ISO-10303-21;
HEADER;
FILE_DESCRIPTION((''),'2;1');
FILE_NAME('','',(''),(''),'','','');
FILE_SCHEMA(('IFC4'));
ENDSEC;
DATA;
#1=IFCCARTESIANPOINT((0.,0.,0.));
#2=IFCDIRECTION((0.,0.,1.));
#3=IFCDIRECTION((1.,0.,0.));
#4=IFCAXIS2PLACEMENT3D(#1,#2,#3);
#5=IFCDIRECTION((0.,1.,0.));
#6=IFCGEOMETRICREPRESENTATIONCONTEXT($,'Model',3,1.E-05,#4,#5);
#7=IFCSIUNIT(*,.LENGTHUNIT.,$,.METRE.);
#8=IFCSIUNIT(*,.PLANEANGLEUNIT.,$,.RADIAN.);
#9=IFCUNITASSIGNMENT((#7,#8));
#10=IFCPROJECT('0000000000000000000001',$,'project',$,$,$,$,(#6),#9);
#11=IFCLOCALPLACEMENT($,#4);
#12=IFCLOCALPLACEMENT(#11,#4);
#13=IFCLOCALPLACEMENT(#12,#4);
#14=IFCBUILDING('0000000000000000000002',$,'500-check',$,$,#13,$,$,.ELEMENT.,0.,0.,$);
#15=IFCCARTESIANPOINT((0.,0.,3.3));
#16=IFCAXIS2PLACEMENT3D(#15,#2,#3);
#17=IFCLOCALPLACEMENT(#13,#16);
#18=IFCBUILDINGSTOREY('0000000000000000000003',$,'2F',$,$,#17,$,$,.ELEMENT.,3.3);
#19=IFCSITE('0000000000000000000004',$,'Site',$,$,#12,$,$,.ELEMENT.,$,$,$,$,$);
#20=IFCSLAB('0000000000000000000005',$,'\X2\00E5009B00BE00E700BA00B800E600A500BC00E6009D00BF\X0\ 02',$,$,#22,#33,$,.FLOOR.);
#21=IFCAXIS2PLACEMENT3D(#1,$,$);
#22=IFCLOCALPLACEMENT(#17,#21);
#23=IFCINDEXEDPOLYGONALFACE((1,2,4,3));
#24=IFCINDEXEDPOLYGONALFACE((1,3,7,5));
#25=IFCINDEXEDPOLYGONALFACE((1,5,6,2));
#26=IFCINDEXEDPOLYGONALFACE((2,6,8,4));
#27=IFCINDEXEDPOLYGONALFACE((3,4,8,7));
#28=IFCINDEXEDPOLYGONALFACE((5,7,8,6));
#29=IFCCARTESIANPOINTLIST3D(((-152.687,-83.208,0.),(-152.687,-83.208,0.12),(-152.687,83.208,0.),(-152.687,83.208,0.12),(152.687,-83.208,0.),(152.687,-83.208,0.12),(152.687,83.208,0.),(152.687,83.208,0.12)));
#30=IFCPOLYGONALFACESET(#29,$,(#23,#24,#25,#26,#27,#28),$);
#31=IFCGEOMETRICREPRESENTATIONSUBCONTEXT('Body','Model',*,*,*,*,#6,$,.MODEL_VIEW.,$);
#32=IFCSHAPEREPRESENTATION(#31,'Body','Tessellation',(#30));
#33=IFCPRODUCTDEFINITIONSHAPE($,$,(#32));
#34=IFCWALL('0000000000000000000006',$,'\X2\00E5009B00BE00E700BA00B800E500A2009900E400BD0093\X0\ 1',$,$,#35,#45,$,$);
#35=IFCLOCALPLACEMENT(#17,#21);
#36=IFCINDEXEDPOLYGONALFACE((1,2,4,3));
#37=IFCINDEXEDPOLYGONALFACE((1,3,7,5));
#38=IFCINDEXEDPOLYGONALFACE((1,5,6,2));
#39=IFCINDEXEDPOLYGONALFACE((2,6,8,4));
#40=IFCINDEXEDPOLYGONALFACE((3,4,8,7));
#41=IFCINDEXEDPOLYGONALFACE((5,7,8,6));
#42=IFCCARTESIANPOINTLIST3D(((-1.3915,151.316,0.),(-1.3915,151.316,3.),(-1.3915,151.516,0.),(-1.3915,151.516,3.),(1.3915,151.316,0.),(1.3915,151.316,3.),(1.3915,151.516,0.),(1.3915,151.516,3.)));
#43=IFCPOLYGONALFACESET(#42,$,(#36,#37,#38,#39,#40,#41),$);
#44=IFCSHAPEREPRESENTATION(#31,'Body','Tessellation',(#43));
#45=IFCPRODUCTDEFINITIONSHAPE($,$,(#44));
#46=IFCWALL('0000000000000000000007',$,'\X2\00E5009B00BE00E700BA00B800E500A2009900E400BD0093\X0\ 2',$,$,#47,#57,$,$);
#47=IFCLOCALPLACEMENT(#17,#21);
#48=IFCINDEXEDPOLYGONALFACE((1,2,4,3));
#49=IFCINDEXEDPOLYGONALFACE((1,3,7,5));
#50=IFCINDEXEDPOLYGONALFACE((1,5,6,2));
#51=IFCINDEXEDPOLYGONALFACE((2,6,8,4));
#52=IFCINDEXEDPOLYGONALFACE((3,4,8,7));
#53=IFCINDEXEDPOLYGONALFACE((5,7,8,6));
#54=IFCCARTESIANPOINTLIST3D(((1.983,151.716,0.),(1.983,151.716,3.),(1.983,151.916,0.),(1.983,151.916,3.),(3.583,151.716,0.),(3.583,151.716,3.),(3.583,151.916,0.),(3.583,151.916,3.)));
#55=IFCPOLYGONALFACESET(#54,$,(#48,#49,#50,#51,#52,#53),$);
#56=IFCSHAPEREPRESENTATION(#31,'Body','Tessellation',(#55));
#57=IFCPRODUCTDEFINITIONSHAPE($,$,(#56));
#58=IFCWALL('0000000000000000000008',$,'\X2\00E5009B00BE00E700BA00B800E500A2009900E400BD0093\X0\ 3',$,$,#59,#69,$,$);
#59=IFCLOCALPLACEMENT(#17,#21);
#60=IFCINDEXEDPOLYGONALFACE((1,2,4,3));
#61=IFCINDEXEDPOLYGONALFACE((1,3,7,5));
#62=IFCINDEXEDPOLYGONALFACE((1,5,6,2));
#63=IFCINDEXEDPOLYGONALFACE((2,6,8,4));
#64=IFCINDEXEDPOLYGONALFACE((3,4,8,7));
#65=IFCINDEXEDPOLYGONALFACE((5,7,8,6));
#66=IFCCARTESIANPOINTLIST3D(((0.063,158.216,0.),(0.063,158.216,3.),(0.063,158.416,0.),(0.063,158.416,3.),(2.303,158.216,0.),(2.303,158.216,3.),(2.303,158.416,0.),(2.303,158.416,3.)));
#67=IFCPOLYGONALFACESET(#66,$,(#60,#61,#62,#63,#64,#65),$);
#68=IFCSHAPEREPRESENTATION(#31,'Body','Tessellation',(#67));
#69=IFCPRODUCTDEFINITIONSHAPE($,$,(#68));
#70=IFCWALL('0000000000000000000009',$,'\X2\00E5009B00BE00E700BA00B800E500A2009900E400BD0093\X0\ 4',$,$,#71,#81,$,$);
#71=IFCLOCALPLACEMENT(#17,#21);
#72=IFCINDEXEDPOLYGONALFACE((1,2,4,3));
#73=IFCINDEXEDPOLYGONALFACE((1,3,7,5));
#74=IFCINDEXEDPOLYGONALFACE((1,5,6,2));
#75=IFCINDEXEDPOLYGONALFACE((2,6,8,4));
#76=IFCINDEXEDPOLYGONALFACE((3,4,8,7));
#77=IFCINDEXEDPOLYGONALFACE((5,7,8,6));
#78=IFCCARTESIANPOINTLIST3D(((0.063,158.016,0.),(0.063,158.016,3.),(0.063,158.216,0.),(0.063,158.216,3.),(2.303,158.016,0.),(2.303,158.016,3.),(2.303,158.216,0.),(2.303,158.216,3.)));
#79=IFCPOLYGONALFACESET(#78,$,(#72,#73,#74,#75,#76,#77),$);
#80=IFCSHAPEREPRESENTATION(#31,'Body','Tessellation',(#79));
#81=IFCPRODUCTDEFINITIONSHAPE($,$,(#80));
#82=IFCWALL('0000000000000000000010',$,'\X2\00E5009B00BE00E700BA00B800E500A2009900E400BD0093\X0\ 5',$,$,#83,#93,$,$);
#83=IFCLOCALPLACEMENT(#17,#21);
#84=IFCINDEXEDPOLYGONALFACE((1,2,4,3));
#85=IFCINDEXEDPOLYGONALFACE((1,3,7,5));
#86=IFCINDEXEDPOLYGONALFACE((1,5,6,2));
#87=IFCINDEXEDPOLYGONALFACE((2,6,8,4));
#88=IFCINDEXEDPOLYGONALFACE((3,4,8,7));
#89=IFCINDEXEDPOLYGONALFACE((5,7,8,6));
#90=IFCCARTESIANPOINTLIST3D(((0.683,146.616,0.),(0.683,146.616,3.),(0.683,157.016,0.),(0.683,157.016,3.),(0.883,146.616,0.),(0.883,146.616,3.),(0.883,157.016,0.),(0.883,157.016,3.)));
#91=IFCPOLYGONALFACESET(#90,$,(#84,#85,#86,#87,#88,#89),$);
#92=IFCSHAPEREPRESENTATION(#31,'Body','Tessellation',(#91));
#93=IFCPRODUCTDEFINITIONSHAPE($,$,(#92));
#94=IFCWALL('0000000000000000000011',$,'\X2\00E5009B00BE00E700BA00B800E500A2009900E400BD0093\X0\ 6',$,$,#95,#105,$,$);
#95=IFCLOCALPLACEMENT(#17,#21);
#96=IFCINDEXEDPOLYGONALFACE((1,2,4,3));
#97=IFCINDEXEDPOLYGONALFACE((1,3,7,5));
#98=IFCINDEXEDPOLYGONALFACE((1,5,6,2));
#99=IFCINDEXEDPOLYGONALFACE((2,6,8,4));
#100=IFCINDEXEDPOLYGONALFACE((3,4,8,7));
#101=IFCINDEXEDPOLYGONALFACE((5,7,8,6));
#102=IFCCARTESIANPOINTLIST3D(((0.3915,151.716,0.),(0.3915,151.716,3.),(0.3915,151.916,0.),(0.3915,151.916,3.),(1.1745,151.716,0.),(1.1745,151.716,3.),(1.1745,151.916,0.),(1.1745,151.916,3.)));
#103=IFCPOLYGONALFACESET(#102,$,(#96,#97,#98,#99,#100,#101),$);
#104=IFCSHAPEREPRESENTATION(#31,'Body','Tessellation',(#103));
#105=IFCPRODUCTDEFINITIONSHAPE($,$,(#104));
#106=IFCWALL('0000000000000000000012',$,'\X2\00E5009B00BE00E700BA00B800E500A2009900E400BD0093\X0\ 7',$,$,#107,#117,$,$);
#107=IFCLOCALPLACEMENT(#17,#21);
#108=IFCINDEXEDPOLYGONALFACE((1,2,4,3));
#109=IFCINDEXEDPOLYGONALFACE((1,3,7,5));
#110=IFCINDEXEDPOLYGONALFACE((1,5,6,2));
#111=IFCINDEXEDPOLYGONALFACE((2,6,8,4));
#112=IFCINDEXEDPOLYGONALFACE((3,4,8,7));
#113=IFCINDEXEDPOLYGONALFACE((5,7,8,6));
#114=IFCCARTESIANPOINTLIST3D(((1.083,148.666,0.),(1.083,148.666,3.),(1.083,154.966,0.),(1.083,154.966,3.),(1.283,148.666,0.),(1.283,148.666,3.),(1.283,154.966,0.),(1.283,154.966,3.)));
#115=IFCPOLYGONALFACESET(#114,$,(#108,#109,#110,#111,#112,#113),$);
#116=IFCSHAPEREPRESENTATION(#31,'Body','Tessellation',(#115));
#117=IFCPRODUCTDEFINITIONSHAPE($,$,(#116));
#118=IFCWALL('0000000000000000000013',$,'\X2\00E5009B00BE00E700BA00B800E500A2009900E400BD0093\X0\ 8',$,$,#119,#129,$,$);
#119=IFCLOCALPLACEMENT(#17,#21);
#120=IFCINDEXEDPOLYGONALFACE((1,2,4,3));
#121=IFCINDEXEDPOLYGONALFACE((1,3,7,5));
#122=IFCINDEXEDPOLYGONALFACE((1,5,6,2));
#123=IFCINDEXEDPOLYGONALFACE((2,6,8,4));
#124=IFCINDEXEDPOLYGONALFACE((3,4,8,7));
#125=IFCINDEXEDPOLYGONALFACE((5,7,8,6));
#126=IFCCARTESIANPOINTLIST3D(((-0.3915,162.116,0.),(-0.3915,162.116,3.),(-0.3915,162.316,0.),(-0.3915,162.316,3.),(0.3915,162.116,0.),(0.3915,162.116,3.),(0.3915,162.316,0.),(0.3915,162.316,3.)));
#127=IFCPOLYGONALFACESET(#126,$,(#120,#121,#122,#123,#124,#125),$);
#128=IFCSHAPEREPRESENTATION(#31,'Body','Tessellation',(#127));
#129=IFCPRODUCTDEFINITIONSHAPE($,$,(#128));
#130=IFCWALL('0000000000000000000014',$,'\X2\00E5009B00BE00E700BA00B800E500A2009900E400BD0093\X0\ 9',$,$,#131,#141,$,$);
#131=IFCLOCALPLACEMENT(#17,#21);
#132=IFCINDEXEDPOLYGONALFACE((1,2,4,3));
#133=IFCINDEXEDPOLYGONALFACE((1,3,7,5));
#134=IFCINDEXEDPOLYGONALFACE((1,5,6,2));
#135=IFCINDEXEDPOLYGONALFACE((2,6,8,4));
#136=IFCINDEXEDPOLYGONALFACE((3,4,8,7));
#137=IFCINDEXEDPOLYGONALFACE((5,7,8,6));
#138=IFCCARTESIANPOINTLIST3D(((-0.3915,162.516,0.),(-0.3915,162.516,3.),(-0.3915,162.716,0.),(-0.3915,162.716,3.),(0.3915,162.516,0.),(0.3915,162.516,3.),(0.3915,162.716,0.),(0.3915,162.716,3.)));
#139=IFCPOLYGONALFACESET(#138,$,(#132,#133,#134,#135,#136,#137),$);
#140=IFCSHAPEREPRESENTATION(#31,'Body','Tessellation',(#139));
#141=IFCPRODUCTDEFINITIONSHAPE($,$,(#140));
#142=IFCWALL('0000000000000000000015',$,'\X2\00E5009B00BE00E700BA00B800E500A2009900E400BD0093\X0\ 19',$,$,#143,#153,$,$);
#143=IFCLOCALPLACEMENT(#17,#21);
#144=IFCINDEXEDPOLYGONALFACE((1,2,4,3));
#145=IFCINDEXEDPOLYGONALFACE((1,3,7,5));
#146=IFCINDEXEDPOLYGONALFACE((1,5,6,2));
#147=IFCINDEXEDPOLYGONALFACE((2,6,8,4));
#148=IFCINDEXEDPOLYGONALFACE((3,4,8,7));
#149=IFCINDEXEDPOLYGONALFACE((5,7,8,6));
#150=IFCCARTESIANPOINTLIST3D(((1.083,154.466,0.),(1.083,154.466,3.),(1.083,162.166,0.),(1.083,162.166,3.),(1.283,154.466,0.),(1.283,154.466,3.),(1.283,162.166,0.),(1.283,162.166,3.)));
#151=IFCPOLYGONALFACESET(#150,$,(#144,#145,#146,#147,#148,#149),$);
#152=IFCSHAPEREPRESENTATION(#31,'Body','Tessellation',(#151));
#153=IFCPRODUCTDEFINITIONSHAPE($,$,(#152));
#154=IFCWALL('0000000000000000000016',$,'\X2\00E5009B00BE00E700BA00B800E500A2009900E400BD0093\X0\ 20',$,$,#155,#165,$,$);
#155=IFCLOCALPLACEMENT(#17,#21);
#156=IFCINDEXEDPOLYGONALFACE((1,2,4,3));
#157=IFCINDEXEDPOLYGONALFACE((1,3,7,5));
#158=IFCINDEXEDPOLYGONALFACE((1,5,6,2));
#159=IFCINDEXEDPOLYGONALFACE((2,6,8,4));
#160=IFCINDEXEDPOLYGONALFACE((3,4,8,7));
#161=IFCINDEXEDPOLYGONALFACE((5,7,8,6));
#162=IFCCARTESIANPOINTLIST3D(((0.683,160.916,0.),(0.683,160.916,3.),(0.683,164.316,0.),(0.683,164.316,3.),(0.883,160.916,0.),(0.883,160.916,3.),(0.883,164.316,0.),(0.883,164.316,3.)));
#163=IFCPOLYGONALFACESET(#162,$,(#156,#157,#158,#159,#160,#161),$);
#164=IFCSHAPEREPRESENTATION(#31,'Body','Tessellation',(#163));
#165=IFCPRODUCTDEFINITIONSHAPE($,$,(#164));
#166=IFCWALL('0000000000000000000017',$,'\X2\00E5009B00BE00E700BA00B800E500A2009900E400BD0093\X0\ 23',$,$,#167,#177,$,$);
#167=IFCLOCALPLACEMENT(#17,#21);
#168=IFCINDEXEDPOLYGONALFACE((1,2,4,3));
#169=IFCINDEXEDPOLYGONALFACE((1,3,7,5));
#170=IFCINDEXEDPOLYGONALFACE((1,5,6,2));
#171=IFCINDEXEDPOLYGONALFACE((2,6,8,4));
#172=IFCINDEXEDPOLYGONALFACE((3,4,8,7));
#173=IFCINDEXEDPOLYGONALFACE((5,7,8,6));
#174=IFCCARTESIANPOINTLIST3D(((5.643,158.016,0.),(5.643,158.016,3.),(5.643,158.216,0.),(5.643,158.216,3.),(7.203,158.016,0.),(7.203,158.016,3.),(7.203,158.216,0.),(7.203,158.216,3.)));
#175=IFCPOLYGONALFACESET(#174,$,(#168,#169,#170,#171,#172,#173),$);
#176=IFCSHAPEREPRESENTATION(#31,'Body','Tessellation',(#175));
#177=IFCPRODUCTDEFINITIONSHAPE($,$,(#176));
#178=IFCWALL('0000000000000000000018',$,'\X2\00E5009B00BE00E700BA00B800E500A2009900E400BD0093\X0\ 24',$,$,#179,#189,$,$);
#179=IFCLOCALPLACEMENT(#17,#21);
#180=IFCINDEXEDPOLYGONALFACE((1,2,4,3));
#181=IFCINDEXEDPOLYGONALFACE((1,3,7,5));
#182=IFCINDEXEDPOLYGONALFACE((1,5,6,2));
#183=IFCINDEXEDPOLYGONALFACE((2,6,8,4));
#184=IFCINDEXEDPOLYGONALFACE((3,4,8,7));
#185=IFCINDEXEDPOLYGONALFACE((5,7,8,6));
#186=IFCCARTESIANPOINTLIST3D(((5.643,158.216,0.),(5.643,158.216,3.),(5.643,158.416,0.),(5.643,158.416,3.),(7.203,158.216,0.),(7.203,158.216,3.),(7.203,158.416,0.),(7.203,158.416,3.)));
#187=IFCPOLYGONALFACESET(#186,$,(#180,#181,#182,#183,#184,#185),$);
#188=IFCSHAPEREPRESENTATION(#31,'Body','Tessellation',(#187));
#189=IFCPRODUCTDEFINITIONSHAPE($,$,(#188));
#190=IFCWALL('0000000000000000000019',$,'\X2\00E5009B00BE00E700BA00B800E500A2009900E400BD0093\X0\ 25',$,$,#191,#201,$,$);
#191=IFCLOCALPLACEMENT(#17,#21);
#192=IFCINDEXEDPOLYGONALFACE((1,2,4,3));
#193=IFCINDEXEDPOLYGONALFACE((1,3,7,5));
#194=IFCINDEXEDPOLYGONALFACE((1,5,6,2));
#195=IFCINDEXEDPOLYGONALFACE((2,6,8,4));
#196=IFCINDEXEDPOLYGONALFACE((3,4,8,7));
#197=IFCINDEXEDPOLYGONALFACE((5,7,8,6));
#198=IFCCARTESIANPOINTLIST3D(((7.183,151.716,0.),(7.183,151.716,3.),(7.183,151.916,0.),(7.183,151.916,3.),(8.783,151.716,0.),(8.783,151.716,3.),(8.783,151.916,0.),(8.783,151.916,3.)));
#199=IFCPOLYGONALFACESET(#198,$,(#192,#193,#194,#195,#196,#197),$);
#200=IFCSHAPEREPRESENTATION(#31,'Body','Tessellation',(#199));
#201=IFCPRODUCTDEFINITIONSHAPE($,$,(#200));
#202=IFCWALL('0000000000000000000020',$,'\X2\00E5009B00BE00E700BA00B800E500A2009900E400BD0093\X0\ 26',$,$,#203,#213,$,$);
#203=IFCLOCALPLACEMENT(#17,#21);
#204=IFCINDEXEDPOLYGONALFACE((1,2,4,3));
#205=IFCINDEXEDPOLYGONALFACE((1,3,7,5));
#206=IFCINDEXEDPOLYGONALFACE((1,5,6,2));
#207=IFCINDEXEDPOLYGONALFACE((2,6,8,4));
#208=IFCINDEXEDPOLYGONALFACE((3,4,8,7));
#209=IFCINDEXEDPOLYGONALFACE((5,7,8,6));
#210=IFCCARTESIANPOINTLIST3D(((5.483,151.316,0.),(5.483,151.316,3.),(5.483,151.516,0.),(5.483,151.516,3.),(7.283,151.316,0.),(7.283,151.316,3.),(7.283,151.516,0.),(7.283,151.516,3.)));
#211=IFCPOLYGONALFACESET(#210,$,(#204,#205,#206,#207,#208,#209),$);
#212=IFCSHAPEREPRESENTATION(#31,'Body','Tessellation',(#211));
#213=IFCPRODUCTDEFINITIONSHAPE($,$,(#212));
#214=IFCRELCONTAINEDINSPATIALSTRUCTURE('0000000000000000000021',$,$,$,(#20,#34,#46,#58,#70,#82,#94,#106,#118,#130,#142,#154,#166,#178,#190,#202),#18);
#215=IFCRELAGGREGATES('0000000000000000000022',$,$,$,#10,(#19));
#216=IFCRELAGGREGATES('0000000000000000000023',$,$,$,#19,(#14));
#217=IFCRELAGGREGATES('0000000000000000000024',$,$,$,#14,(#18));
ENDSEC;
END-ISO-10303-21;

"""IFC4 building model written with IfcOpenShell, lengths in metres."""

from ifc_helpers import new_model, si_unit, direction, frame, frame_2d, origin_with_axes, place, context, subcontext, project, spatial, rectangle, extrude, element, save


model = new_model("IFC4")

# Units and contexts
model_context = context("Model", 3, precision=1e-05, world=origin_with_axes(), true_north=direction((0.0, 1.0, 0.0)))
body_context = subcontext(model_context, "Body", "Model", "MODEL_VIEW")
ifc_project = project(units=[si_unit("LENGTHUNIT", "METRE"), si_unit("PLANEANGLEUNIT", "RADIAN")], contexts=[model_context])

# Site, building, storey
placement = place(None, origin_with_axes())
site_placement = place(placement, origin_with_axes())
site = spatial("IfcSite", under=ifc_project, at=site_placement, Name="Site", CompositionType="ELEMENT")
building_placement = place(site_placement, origin_with_axes())
building = spatial("IfcBuilding", under=site, at=building_placement, Name="500-check", CompositionType="ELEMENT", ElevationOfRefHeight=0.0, ElevationOfTerrain=0.0)
storey_placement = place(building_placement, frame((0.0, 0.0, 3.3), z_axis=(0.0, 0.0, 1.0), x_axis=(1.0, 0.0, 0.0)))
storey = spatial("IfcBuildingStorey", under=building, at=storey_placement, Name="2F", CompositionType="ELEMENT", Elevation=3.3)

# Slab
slab_placement = place(storey_placement, origin_with_axes())
element("IfcSlab", 1, at=slab_placement, inside=storey, Name="å\u009b¾çº¸æ¥¼æ\u009d¿ 02", PredefinedType="FLOOR", context=body_context, shape_type="SweptSolid", body=[
    extrude(rectangle(XDim=305.374, YDim=166.416, at=frame_2d((0.0, 0.0), x_axis=(1.0, 0.0, 0.0))), frame((0.0, 0.0, 0.0), z_axis=(0.0, 0.0, 1.0)), (0.0, 0.0, 1.0), 0.12),
])

# Walls
wall_1_placement = place(storey_placement, frame((0.0, 151.416, 0.0), z_axis=(0.0, 0.0, 1.0), x_axis=(1.0, 0.0, 0.0)))
element("IfcWall", 2, at=wall_1_placement, inside=storey, Name="å\u009b¾çº¸å¢\u0099ä½\u0093 1", context=body_context, shape_type="SweptSolid", body=[
    extrude(rectangle(XDim=2.783, YDim=0.2, at=frame_2d((0.0, 0.0), x_axis=(1.0, 0.0, 0.0))), frame((0.0, 0.0, 0.0), z_axis=(0.0, 0.0, 1.0)), (0.0, 0.0, 1.0), 3.0),
])
wall_2_placement = place(storey_placement, frame((2.783, 151.816, 0.0), z_axis=(0.0, 0.0, 1.0), x_axis=(-1.0, 0.0, 0.0)))
element("IfcWall", 3, at=wall_2_placement, inside=storey, Name="å\u009b¾çº¸å¢\u0099ä½\u0093 2", context=body_context, shape_type="SweptSolid", body=[
    extrude(rectangle(XDim=1.6, YDim=0.2, at=frame_2d((0.0, 0.0), x_axis=(1.0, 0.0, 0.0))), frame((0.0, 0.0, 0.0), z_axis=(0.0, 0.0, 1.0)), (0.0, 0.0, 1.0), 3.0),
])
for number, where, z_axis, x_axis, name in (
    (4, (1.183, 158.316, 0.0), (0.0, 0.0, 1.0), (1.0, 0.0, 0.0), "å\u009b¾çº¸å¢\u0099ä½\u0093 3"),
    (5, (1.183, 158.116, 0.0), (0.0, 0.0, 1.0), (1.0, 0.0, 0.0), "å\u009b¾çº¸å¢\u0099ä½\u0093 4"),
):
    element("IfcWall", number, at=place(storey_placement, frame(where, z_axis=z_axis, x_axis=x_axis)), inside=storey, Name=name, context=body_context, shape_type="SweptSolid", body=[
        extrude(rectangle(XDim=2.24, YDim=0.2, at=frame_2d((0.0, 0.0), x_axis=(1.0, 0.0, 0.0))), frame((0.0, 0.0, 0.0), z_axis=(0.0, 0.0, 1.0)), (0.0, 0.0, 1.0), 3.0),
    ])
wall_3_placement = place(storey_placement, frame((0.783, 151.816, 0.0), z_axis=(0.0, 0.0, 1.0), x_axis=(0.0, 1.0, 0.0)))
element("IfcWall", 6, at=wall_3_placement, inside=storey, Name="å\u009b¾çº¸å¢\u0099ä½\u0093 5", context=body_context, shape_type="SweptSolid", body=[
    extrude(rectangle(XDim=10.4, YDim=0.2, at=frame_2d((0.0, 0.0), x_axis=(1.0, 0.0, 0.0))), frame((0.0, 0.0, 0.0), z_axis=(0.0, 0.0, 1.0)), (0.0, 0.0, 1.0), 3.0),
])
wall_4_placement = place(storey_placement, frame((0.783, 151.816, 0.0), z_axis=(0.0, 0.0, 1.0), x_axis=(-1.0, 0.0, 0.0)))
element("IfcWall", 7, at=wall_4_placement, inside=storey, Name="å\u009b¾çº¸å¢\u0099ä½\u0093 6", context=body_context, shape_type="SweptSolid", body=[
    extrude(rectangle(XDim=0.783, YDim=0.2, at=frame_2d((0.0, 0.0), x_axis=(1.0, 0.0, 0.0))), frame((0.0, 0.0, 0.0), z_axis=(0.0, 0.0, 1.0)), (0.0, 0.0, 1.0), 3.0),
])
wall_5_placement = place(storey_placement, frame((1.183, 151.816, 0.0), z_axis=(0.0, 0.0, 1.0), x_axis=(0.0, 1.0, 0.0)))
element("IfcWall", 8, at=wall_5_placement, inside=storey, Name="å\u009b¾çº¸å¢\u0099ä½\u0093 7", context=body_context, shape_type="SweptSolid", body=[
    extrude(rectangle(XDim=6.3, YDim=0.2, at=frame_2d((0.0, 0.0), x_axis=(1.0, 0.0, 0.0))), frame((0.0, 0.0, 0.0), z_axis=(0.0, 0.0, 1.0)), (0.0, 0.0, 1.0), 3.0),
])
for number, where, z_axis, x_axis, name in (
    (9, (0.0, 162.216, 0.0), (0.0, 0.0, 1.0), (1.0, 0.0, 0.0), "å\u009b¾çº¸å¢\u0099ä½\u0093 8"),
    (10, (0.0, 162.616, 0.0), (0.0, 0.0, 1.0), (1.0, 0.0, 0.0), "å\u009b¾çº¸å¢\u0099ä½\u0093 9"),
):
    element("IfcWall", number, at=place(storey_placement, frame(where, z_axis=z_axis, x_axis=x_axis)), inside=storey, Name=name, context=body_context, shape_type="SweptSolid", body=[
        extrude(rectangle(XDim=0.783, YDim=0.2, at=frame_2d((0.0, 0.0), x_axis=(1.0, 0.0, 0.0))), frame((0.0, 0.0, 0.0), z_axis=(0.0, 0.0, 1.0)), (0.0, 0.0, 1.0), 3.0),
    ])
wall_6_placement = place(storey_placement, frame((1.183, 158.316, 0.0), z_axis=(0.0, 0.0, 1.0), x_axis=(0.0, 1.0, 0.0)))
element("IfcWall", 11, at=wall_6_placement, inside=storey, Name="å\u009b¾çº¸å¢\u0099ä½\u0093 19", context=body_context, shape_type="SweptSolid", body=[
    extrude(rectangle(XDim=7.7, YDim=0.2, at=frame_2d((0.0, 0.0), x_axis=(1.0, 0.0, 0.0))), frame((0.0, 0.0, 0.0), z_axis=(0.0, 0.0, 1.0)), (0.0, 0.0, 1.0), 3.0),
])
wall_7_placement = place(storey_placement, frame((0.783, 162.616, 0.0), z_axis=(0.0, 0.0, 1.0), x_axis=(0.0, 1.0, 0.0)))
element("IfcWall", 12, at=wall_7_placement, inside=storey, Name="å\u009b¾çº¸å¢\u0099ä½\u0093 20", context=body_context, shape_type="SweptSolid", body=[
    extrude(rectangle(XDim=3.4, YDim=0.2, at=frame_2d((0.0, 0.0), x_axis=(1.0, 0.0, 0.0))), frame((0.0, 0.0, 0.0), z_axis=(0.0, 0.0, 1.0)), (0.0, 0.0, 1.0), 3.0),
])
for number, where, z_axis, x_axis, name in (
    (13, (6.423, 158.116, 0.0), (0.0, 0.0, 1.0), (1.0, 0.0, 0.0), "å\u009b¾çº¸å¢\u0099ä½\u0093 23"),
    (14, (6.423, 158.316, 0.0), (0.0, 0.0, 1.0), (1.0, 0.0, 0.0), "å\u009b¾çº¸å¢\u0099ä½\u0093 24"),
):
    element("IfcWall", number, at=place(storey_placement, frame(where, z_axis=z_axis, x_axis=x_axis)), inside=storey, Name=name, context=body_context, shape_type="SweptSolid", body=[
        extrude(rectangle(XDim=1.56, YDim=0.2, at=frame_2d((0.0, 0.0), x_axis=(1.0, 0.0, 0.0))), frame((0.0, 0.0, 0.0), z_axis=(0.0, 0.0, 1.0)), (0.0, 0.0, 1.0), 3.0),
    ])
wall_8_placement = place(storey_placement, frame((7.983, 151.816, 0.0), z_axis=(0.0, 0.0, 1.0), x_axis=(-1.0, 0.0, 0.0)))
element("IfcWall", 15, at=wall_8_placement, inside=storey, Name="å\u009b¾çº¸å¢\u0099ä½\u0093 25", context=body_context, shape_type="SweptSolid", body=[
    extrude(rectangle(XDim=1.6, YDim=0.2, at=frame_2d((0.0, 0.0), x_axis=(1.0, 0.0, 0.0))), frame((0.0, 0.0, 0.0), z_axis=(0.0, 0.0, 1.0)), (0.0, 0.0, 1.0), 3.0),
])
wall_9_placement = place(storey_placement, frame((6.383, 151.416, 0.0), z_axis=(0.0, 0.0, 1.0), x_axis=(1.0, 0.0, 0.0)))
element("IfcWall", 16, at=wall_9_placement, inside=storey, Name="å\u009b¾çº¸å¢\u0099ä½\u0093 26", context=body_context, shape_type="SweptSolid", body=[
    extrude(rectangle(XDim=1.8, YDim=0.2, at=frame_2d((0.0, 0.0), x_axis=(1.0, 0.0, 0.0))), frame((0.0, 0.0, 0.0), z_axis=(0.0, 0.0, 1.0)), (0.0, 0.0, 1.0), 3.0),
])

save(model, "model.ifc")
